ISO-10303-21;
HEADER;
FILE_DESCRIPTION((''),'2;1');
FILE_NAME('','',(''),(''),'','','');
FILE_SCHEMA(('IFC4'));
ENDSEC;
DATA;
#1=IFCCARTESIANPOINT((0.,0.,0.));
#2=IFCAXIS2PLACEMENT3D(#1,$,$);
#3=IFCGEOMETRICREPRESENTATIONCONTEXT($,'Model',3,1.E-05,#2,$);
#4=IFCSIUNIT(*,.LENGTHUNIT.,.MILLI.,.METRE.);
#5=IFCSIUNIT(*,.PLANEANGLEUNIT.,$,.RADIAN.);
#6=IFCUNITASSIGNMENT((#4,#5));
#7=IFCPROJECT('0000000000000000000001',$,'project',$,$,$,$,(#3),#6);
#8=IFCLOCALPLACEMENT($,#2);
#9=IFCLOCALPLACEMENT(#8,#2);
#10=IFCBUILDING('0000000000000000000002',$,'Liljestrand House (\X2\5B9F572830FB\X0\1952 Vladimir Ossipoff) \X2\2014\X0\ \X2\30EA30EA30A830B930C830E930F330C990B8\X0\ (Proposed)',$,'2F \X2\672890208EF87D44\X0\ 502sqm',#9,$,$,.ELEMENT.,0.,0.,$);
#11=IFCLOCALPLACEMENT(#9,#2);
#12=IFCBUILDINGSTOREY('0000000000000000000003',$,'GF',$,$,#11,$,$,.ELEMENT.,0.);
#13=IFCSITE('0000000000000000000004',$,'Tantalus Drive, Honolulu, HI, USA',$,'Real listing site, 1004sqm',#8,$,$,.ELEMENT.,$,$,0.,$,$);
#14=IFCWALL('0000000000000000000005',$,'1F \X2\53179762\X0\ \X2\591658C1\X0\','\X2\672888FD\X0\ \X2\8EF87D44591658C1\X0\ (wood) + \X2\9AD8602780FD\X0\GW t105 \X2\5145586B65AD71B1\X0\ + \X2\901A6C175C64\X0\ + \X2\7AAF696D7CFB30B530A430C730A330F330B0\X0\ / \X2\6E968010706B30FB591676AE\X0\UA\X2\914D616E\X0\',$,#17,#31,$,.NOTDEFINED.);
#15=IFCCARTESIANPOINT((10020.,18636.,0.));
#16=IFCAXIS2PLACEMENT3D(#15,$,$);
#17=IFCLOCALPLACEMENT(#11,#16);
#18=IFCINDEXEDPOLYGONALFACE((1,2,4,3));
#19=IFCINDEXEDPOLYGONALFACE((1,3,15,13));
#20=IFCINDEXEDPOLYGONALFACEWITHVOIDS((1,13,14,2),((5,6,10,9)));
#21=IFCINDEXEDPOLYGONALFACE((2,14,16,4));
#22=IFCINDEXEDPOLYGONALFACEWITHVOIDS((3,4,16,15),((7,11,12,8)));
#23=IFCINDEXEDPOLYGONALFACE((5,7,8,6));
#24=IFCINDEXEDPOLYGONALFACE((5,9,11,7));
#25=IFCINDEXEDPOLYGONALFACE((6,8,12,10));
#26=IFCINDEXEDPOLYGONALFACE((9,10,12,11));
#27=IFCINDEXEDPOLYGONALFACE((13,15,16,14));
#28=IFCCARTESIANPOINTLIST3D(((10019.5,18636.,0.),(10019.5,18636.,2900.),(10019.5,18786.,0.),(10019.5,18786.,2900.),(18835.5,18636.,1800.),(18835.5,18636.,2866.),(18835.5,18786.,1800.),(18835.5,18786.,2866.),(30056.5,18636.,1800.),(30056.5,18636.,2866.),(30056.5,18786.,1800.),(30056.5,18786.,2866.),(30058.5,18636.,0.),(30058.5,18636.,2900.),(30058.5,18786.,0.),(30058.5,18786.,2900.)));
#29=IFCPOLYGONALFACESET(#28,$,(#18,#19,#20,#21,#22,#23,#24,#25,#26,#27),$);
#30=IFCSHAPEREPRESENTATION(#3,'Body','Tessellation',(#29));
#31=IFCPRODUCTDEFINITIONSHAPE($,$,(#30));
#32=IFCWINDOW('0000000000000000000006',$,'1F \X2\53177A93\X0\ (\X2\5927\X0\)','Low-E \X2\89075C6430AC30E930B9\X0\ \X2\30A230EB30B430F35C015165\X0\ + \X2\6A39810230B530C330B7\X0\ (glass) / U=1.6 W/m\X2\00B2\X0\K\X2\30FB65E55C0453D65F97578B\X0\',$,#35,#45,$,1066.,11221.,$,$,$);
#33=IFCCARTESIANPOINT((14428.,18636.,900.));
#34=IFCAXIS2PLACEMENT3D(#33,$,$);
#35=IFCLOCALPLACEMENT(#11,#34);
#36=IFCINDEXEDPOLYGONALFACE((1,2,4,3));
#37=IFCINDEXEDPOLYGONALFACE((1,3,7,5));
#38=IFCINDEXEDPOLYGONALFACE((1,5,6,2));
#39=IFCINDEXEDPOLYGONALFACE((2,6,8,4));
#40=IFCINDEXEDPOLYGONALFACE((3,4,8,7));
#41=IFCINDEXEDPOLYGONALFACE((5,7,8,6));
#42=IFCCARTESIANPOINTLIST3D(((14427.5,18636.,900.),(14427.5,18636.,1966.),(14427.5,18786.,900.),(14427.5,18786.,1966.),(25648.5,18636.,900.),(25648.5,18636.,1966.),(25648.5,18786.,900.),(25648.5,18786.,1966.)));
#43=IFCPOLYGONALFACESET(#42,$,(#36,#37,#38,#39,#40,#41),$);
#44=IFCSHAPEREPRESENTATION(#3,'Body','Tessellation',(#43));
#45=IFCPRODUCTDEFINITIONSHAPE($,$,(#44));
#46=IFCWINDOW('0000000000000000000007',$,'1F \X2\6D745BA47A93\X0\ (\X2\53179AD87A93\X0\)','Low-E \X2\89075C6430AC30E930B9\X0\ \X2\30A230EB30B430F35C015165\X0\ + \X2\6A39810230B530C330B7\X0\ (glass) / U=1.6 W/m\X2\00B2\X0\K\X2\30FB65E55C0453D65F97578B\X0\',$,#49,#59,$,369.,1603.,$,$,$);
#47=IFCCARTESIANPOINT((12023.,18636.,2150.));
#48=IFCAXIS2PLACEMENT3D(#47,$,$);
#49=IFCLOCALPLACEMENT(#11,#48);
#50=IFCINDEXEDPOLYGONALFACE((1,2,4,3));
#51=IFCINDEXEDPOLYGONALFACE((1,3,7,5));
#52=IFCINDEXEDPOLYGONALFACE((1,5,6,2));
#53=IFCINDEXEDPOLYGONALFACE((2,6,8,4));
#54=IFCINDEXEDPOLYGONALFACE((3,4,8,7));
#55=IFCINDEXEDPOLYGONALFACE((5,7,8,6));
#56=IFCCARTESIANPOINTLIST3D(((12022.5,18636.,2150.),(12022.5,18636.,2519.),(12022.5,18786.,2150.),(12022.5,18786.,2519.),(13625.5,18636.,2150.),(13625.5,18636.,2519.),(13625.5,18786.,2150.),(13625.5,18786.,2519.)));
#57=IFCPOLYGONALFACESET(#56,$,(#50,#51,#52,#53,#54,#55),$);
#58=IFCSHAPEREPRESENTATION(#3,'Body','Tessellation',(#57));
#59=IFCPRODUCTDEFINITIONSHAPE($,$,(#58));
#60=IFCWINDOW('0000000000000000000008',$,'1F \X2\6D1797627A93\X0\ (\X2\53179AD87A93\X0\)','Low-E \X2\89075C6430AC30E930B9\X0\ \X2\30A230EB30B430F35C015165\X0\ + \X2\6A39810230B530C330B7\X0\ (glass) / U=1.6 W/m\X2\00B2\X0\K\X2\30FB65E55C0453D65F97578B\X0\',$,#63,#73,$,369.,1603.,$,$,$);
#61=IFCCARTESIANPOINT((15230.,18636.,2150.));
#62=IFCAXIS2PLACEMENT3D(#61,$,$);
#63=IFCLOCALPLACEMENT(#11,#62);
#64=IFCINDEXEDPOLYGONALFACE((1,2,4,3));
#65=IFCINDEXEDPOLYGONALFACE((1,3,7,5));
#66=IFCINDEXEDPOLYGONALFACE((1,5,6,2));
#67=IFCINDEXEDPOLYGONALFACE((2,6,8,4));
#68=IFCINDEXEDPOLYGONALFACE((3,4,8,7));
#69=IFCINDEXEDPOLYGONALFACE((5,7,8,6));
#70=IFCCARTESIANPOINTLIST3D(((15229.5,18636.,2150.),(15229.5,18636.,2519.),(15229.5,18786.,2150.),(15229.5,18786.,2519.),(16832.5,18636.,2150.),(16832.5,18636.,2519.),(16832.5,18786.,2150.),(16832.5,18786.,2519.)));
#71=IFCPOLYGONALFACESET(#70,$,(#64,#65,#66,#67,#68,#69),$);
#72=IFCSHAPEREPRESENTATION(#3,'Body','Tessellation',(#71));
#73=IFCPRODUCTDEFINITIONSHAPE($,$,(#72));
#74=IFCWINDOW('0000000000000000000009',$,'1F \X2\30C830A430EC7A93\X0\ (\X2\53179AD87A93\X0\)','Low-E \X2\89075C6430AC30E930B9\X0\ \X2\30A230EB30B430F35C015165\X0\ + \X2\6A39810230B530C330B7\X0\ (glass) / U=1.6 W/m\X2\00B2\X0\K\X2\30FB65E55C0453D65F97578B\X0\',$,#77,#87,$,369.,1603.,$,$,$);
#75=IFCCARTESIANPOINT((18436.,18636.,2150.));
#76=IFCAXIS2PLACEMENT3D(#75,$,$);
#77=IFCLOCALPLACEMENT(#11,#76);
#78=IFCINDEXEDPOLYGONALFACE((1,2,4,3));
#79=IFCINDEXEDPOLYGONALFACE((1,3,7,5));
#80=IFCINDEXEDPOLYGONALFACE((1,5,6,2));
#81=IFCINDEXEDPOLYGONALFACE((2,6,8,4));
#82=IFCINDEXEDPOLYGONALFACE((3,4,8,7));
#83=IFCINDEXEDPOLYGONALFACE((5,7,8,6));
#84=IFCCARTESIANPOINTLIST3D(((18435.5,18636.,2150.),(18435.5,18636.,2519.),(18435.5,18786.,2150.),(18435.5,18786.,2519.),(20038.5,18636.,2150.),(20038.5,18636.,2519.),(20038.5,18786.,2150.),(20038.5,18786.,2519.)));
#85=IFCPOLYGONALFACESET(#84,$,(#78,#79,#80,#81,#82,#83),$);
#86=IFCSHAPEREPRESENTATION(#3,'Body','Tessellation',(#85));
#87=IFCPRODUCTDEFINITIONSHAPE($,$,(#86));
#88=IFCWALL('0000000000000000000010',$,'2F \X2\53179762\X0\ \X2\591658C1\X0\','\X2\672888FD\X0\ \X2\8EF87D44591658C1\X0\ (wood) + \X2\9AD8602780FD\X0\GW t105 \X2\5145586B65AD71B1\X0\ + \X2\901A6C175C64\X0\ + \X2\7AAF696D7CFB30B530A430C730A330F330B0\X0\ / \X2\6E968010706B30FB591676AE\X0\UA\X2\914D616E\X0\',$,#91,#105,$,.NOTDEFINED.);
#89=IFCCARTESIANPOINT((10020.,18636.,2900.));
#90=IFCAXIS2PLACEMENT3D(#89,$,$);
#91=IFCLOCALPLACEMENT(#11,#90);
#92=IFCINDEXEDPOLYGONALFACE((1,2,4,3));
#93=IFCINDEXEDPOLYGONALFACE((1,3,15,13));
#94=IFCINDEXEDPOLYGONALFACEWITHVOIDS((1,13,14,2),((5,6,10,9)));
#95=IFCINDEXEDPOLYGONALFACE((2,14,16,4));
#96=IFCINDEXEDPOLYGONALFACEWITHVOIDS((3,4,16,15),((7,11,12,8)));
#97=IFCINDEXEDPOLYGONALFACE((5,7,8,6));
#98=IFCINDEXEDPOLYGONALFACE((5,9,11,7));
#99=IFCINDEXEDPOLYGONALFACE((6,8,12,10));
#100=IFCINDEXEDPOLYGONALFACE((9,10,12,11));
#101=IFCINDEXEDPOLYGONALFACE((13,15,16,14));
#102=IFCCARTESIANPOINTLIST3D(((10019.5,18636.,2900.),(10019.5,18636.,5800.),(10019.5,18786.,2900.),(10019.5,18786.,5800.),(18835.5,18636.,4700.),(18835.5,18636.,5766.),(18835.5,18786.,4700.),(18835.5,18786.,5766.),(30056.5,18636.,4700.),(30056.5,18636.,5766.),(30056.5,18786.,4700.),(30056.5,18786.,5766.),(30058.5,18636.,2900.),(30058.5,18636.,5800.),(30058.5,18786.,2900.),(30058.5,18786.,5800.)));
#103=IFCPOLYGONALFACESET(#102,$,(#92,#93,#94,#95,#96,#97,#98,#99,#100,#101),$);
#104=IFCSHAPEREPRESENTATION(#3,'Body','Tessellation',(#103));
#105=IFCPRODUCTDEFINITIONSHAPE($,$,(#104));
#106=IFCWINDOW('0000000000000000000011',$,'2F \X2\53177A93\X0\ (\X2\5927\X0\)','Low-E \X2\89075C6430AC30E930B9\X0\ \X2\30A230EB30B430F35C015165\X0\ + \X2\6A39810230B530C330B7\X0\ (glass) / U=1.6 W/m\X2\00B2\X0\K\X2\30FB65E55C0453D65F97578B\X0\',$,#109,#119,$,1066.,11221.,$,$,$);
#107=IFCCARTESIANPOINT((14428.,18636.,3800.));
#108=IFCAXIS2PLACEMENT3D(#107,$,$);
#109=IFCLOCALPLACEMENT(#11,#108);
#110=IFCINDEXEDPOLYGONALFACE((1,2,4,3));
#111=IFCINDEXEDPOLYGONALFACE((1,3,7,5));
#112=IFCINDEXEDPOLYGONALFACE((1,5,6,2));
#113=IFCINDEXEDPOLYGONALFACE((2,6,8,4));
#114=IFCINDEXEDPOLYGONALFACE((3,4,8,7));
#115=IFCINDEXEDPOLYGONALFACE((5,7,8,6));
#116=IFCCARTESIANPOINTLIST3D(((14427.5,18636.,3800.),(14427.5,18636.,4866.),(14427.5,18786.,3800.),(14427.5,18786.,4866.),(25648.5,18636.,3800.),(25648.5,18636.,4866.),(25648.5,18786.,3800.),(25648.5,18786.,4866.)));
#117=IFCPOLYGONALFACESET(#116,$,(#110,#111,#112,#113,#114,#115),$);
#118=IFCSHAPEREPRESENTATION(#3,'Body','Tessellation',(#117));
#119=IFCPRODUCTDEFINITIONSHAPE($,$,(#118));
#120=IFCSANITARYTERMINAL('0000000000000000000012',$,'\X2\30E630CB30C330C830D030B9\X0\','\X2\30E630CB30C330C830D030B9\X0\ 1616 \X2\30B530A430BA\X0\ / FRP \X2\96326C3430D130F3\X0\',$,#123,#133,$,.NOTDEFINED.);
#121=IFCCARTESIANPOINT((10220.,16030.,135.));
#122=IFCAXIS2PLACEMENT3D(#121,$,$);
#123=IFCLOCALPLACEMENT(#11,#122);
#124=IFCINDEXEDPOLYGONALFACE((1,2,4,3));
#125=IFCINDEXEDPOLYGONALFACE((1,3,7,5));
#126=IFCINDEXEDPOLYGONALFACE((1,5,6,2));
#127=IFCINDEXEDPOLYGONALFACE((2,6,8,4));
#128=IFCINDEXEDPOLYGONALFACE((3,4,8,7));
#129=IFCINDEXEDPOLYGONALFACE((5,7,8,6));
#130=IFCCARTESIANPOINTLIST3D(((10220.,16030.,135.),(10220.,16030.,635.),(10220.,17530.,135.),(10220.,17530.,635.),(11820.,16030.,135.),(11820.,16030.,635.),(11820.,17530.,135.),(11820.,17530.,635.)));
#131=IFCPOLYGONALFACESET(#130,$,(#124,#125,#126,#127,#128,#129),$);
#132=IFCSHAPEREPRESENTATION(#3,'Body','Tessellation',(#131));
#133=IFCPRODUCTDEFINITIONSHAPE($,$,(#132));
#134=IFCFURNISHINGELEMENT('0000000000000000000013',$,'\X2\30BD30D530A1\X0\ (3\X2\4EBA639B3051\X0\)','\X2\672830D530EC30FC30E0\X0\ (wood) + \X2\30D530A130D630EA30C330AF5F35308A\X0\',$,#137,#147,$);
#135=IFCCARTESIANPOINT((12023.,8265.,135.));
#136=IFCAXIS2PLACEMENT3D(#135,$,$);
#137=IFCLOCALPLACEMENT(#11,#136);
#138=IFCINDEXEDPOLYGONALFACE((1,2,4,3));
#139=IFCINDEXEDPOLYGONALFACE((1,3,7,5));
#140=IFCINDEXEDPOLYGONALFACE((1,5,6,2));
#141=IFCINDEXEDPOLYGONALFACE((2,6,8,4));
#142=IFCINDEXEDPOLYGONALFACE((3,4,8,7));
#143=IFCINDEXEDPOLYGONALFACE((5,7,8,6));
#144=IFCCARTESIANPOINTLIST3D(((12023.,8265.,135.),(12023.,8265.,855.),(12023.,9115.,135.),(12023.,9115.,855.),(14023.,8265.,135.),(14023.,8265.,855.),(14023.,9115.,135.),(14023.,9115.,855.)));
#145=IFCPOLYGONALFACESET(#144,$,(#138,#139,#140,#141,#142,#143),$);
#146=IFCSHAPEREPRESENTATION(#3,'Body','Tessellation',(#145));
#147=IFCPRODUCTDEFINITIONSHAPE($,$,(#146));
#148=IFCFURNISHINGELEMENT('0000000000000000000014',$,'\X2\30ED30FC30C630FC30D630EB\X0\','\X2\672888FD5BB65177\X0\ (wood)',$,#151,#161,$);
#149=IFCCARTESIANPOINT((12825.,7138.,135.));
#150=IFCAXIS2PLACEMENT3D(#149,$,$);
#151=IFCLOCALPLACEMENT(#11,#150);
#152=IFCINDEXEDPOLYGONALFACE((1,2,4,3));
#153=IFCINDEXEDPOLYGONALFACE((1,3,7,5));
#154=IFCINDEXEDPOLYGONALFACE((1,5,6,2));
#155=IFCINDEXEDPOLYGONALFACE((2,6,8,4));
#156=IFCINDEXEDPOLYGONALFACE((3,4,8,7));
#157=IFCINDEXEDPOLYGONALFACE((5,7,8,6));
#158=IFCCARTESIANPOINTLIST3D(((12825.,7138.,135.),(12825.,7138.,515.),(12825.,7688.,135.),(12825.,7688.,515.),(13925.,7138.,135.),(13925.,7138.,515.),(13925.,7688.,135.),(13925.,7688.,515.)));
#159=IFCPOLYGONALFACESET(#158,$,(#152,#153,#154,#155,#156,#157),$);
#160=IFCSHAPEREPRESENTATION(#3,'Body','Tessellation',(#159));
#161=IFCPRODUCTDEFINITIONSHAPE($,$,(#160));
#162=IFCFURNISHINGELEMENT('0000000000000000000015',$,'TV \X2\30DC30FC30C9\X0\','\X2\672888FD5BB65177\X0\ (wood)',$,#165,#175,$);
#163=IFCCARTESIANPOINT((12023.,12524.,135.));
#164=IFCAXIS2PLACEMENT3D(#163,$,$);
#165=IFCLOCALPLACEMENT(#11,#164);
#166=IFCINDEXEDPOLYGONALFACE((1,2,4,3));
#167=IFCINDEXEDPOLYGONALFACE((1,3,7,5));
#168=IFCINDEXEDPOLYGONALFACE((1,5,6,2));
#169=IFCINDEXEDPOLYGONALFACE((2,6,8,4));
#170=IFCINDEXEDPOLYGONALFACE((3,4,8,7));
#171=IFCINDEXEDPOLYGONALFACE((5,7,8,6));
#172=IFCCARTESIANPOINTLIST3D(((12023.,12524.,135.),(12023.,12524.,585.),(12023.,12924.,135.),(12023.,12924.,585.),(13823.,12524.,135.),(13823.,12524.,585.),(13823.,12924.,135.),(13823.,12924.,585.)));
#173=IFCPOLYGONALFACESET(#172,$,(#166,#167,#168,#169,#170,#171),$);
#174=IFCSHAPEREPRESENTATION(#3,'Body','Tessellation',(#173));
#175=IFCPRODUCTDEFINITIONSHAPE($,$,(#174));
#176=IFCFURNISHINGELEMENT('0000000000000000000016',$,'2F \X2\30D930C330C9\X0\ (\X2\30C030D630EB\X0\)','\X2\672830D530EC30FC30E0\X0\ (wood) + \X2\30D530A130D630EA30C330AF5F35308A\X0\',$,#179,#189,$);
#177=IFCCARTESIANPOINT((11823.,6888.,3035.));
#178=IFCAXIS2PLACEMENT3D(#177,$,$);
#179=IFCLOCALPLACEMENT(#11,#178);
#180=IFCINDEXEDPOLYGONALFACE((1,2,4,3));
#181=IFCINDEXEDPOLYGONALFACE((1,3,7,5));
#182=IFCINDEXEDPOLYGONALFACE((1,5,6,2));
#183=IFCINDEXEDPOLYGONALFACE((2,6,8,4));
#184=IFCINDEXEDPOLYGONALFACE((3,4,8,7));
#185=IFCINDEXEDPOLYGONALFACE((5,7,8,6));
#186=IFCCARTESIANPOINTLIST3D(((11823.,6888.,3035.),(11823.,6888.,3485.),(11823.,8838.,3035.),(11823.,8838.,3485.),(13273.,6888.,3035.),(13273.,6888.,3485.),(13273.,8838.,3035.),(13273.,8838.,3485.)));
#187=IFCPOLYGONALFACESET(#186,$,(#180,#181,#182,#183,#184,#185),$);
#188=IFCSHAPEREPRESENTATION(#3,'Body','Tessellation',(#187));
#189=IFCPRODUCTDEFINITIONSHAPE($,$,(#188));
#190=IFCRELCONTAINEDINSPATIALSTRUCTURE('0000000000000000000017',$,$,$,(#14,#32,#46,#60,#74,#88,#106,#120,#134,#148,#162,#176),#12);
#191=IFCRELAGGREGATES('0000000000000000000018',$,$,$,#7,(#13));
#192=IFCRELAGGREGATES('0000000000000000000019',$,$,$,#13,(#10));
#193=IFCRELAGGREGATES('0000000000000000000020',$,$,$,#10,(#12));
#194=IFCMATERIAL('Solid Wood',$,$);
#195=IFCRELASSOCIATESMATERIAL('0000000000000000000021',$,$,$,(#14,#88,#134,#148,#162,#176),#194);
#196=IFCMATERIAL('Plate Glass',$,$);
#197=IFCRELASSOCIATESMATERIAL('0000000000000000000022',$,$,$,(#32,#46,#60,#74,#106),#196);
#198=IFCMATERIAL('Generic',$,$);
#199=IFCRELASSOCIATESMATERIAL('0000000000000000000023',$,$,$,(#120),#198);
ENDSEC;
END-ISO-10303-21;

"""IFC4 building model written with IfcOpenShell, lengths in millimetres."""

from ifc_helpers import new_model, si_unit, frame, frame_2d, origin, place, context, project, spatial, rectangle, extrude, material, element, fill, save


model = new_model("IFC4")

# Units and contexts
model_context = context("Model", 3, precision=1e-05, world=origin())
ifc_project = project(units=[si_unit("LENGTHUNIT", "METRE", prefix="MILLI"), si_unit("PLANEANGLEUNIT", "RADIAN")], contexts=[model_context])

# Site, building, storey
site_placement = place(None, origin())
site = spatial("IfcSite", under=ifc_project, at=site_placement, Name="Tantalus Drive, Honolulu, HI, USA", ObjectType="Real listing site, 1004sqm", CompositionType="ELEMENT", RefElevation=0.0)
building_placement = place(site_placement, origin())
building = spatial("IfcBuilding", under=site, at=building_placement, Name="Liljestrand House (実在・1952 Vladimir Ossipoff) — リリエストランド邸 (Proposed)", ObjectType="2F 木造軸組 502sqm", CompositionType="ELEMENT", ElevationOfRefHeight=0.0, ElevationOfTerrain=0.0)
storey_placement = place(building_placement, origin())
storey = spatial("IfcBuildingStorey", under=building, at=storey_placement, Name="GF", CompositionType="ELEMENT", Elevation=0.0)

# Wall, openings, windows
ifc_material_1 = material(Name="Solid Wood")
wall_1_placement = place(storey_placement, frame((10020.0, 18636.0, 0.0)))
wall_1 = element("IfcWall", 1, at=wall_1_placement, inside=storey, material=ifc_material_1, Name="1F 北面 外壁", Description="木製 軸組外壁 (wood) + 高性能GW t105 充填断熱 + 通気層 + 窯業系サイディング / 準耐火・外皮UA配慮", PredefinedType="NOTDEFINED", context=model_context, shape_type="SweptSolid", body=[
    extrude(rectangle(XDim=20039.0, YDim=150.0, at=frame_2d((10019.0, 75.0))), frame((10020.0, 18636.0, 0.0)), (0.0, 0.0, 1.0), 2900.0),
])
opening_1_placement = place(storey_placement, frame((14428.0, 18636.0, 900.0)))
opening_1 = element("IfcOpeningElement", 2, at=opening_1_placement, cuts=wall_1, PredefinedType="NOTDEFINED", context=model_context, shape_type="SweptSolid", body=[
    extrude(rectangle(XDim=11221.0, YDim=150.0, at=frame_2d((5610.0, 75.0))), frame((14428.0, 18636.0, 900.0)), (0.0, 0.0, 1.0), 1066.0),
])
opening_2_placement = place(storey_placement, frame((12023.0, 18636.0, 2150.0)))
opening_2 = element("IfcOpeningElement", 3, at=opening_2_placement, cuts=wall_1, PredefinedType="NOTDEFINED", context=model_context, shape_type="SweptSolid", body=[
    extrude(rectangle(XDim=1603.0, YDim=150.0, at=frame_2d((801.0, 75.0))), frame((12023.0, 18636.0, 2150.0)), (0.0, 0.0, 1.0), 369.0),
])
opening_3_placement = place(storey_placement, frame((15230.0, 18636.0, 2150.0)))
opening_3 = element("IfcOpeningElement", 4, at=opening_3_placement, cuts=wall_1, PredefinedType="NOTDEFINED", context=model_context, shape_type="SweptSolid", body=[
    extrude(rectangle(XDim=1603.0, YDim=150.0, at=frame_2d((801.0, 75.0))), frame((15230.0, 18636.0, 2150.0)), (0.0, 0.0, 1.0), 369.0),
])
opening_4_placement = place(storey_placement, frame((18436.0, 18636.0, 2150.0)))
opening_4 = element("IfcOpeningElement", 5, at=opening_4_placement, cuts=wall_1, PredefinedType="NOTDEFINED", context=model_context, shape_type="SweptSolid", body=[
    extrude(rectangle(XDim=1603.0, YDim=150.0, at=frame_2d((801.0, 75.0))), frame((18436.0, 18636.0, 2150.0)), (0.0, 0.0, 1.0), 369.0),
])
ifc_material_2 = material(Name="Plate Glass")
window_1_placement = place(storey_placement, frame((14428.0, 18636.0, 900.0)))
window_1 = element("IfcWindow", 6, at=window_1_placement, inside=storey, material=ifc_material_2, Name="1F 北窓 (大)", Description="Low-E 複層ガラス アルゴン封入 + 樹脂サッシ (glass) / U=1.6 W/m²K・日射取得型", OverallHeight=1066.0, OverallWidth=11221.0, context=model_context, shape_type="SweptSolid", body=[
    extrude(rectangle(XDim=11221.0, YDim=150.0, at=frame_2d((5610.0, 75.0))), frame((14428.0, 18636.0, 900.0)), (0.0, 0.0, 1.0), 1066.0),
])
fill(opening_1, window_1)
window_2_placement = place(storey_placement, frame((12023.0, 18636.0, 2150.0)))
window_2 = element("IfcWindow", 7, at=window_2_placement, inside=storey, material=ifc_material_2, Name="1F 浴室窓 (北高窓)", Description="Low-E 複層ガラス アルゴン封入 + 樹脂サッシ (glass) / U=1.6 W/m²K・日射取得型", OverallHeight=369.0, OverallWidth=1603.0, context=model_context, shape_type="SweptSolid", body=[
    extrude(rectangle(XDim=1603.0, YDim=150.0, at=frame_2d((801.0, 75.0))), frame((12023.0, 18636.0, 2150.0)), (0.0, 0.0, 1.0), 369.0),
])
fill(opening_2, window_2)
window_3_placement = place(storey_placement, frame((15230.0, 18636.0, 2150.0)))
window_3 = element("IfcWindow", 8, at=window_3_placement, inside=storey, material=ifc_material_2, Name="1F 洗面窓 (北高窓)", Description="Low-E 複層ガラス アルゴン封入 + 樹脂サッシ (glass) / U=1.6 W/m²K・日射取得型", OverallHeight=369.0, OverallWidth=1603.0, context=model_context, shape_type="SweptSolid", body=[
    extrude(rectangle(XDim=1603.0, YDim=150.0, at=frame_2d((801.0, 75.0))), frame((15230.0, 18636.0, 2150.0)), (0.0, 0.0, 1.0), 369.0),
])
fill(opening_3, window_3)
window_4_placement = place(storey_placement, frame((18436.0, 18636.0, 2150.0)))
window_4 = element("IfcWindow", 9, at=window_4_placement, inside=storey, material=ifc_material_2, Name="1F トイレ窓 (北高窓)", Description="Low-E 複層ガラス アルゴン封入 + 樹脂サッシ (glass) / U=1.6 W/m²K・日射取得型", OverallHeight=369.0, OverallWidth=1603.0, context=model_context, shape_type="SweptSolid", body=[
    extrude(rectangle(XDim=1603.0, YDim=150.0, at=frame_2d((801.0, 75.0))), frame((18436.0, 18636.0, 2150.0)), (0.0, 0.0, 1.0), 369.0),
])
fill(opening_4, window_4)

# Wall, opening, window
wall_2_placement = place(storey_placement, frame((10020.0, 18636.0, 2900.0)))
wall_2 = element("IfcWall", 10, at=wall_2_placement, inside=storey, material=ifc_material_1, Name="2F 北面 外壁", Description="木製 軸組外壁 (wood) + 高性能GW t105 充填断熱 + 通気層 + 窯業系サイディング / 準耐火・外皮UA配慮", PredefinedType="NOTDEFINED", context=model_context, shape_type="SweptSolid", body=[
    extrude(rectangle(XDim=20039.0, YDim=150.0, at=frame_2d((10019.0, 75.0))), frame((10020.0, 18636.0, 2900.0)), (0.0, 0.0, 1.0), 2900.0),
])
opening_5_placement = place(storey_placement, frame((14428.0, 18636.0, 3800.0)))
opening_5 = element("IfcOpeningElement", 11, at=opening_5_placement, cuts=wall_2, PredefinedType="NOTDEFINED", context=model_context, shape_type="SweptSolid", body=[
    extrude(rectangle(XDim=11221.0, YDim=150.0, at=frame_2d((5610.0, 75.0))), frame((14428.0, 18636.0, 3800.0)), (0.0, 0.0, 1.0), 1066.0),
])
window_5_placement = place(storey_placement, frame((14428.0, 18636.0, 3800.0)))
window_5 = element("IfcWindow", 12, at=window_5_placement, inside=storey, material=ifc_material_2, Name="2F 北窓 (大)", Description="Low-E 複層ガラス アルゴン封入 + 樹脂サッシ (glass) / U=1.6 W/m²K・日射取得型", OverallHeight=1066.0, OverallWidth=11221.0, context=model_context, shape_type="SweptSolid", body=[
    extrude(rectangle(XDim=11221.0, YDim=150.0, at=frame_2d((5610.0, 75.0))), frame((14428.0, 18636.0, 3800.0)), (0.0, 0.0, 1.0), 1066.0),
])
fill(opening_5, window_5)

# Sanitary terminal
ifc_material_3 = material(Name="Generic")
sanitary_terminal_placement = place(storey_placement, frame((10220.0, 16030.0, 135.0)))
element("IfcSanitaryTerminal", 13, at=sanitary_terminal_placement, inside=storey, material=ifc_material_3, Name="ユニットバス", Description="ユニットバス 1616 サイズ / FRP 防水パン", PredefinedType="NOTDEFINED", context=model_context, shape_type="SweptSolid", body=[
    extrude(rectangle(XDim=1600.0, YDim=1500.0, at=frame_2d((800.0, 750.0))), frame((10220.0, 16030.0, 135.0)), (0.0, 0.0, 1.0), 500.0),
])

# Furnishing elements
furnishing_1_placement = place(storey_placement, frame((12023.0, 8265.0, 135.0)))
element("IfcFurnishingElement", 14, at=furnishing_1_placement, inside=storey, material=ifc_material_1, Name="ソファ (3人掛け)", Description="木フレーム (wood) + ファブリック張り", context=model_context, shape_type="SweptSolid", body=[
    extrude(rectangle(XDim=2000.0, YDim=850.0, at=frame_2d((1000.0, 425.0))), frame((12023.0, 8265.0, 135.0)), (0.0, 0.0, 1.0), 720.0),
])
furnishing_2_placement = place(storey_placement, frame((12825.0, 7138.0, 135.0)))
element("IfcFurnishingElement", 15, at=furnishing_2_placement, inside=storey, material=ifc_material_1, Name="ローテーブル", Description="木製家具 (wood)", context=model_context, shape_type="SweptSolid", body=[
    extrude(rectangle(XDim=1100.0, YDim=550.0, at=frame_2d((550.0, 275.0))), frame((12825.0, 7138.0, 135.0)), (0.0, 0.0, 1.0), 380.0),
])
furnishing_3_placement = place(storey_placement, frame((12023.0, 12524.0, 135.0)))
element("IfcFurnishingElement", 16, at=furnishing_3_placement, inside=storey, material=ifc_material_1, Name="TV ボード", Description="木製家具 (wood)", context=model_context, shape_type="SweptSolid", body=[
    extrude(rectangle(XDim=1800.0, YDim=400.0, at=frame_2d((900.0, 200.0))), frame((12023.0, 12524.0, 135.0)), (0.0, 0.0, 1.0), 450.0),
])
furnishing_4_placement = place(storey_placement, frame((11823.0, 6888.0, 3035.0)))
element("IfcFurnishingElement", 17, at=furnishing_4_placement, inside=storey, material=ifc_material_1, Name="2F ベッド (ダブル)", Description="木フレーム (wood) + ファブリック張り", context=model_context, shape_type="SweptSolid", body=[
    extrude(rectangle(XDim=1450.0, YDim=1950.0, at=frame_2d((725.0, 975.0))), frame((11823.0, 6888.0, 3035.0)), (0.0, 0.0, 1.0), 450.0),
])

save(model, "model.ifc")
